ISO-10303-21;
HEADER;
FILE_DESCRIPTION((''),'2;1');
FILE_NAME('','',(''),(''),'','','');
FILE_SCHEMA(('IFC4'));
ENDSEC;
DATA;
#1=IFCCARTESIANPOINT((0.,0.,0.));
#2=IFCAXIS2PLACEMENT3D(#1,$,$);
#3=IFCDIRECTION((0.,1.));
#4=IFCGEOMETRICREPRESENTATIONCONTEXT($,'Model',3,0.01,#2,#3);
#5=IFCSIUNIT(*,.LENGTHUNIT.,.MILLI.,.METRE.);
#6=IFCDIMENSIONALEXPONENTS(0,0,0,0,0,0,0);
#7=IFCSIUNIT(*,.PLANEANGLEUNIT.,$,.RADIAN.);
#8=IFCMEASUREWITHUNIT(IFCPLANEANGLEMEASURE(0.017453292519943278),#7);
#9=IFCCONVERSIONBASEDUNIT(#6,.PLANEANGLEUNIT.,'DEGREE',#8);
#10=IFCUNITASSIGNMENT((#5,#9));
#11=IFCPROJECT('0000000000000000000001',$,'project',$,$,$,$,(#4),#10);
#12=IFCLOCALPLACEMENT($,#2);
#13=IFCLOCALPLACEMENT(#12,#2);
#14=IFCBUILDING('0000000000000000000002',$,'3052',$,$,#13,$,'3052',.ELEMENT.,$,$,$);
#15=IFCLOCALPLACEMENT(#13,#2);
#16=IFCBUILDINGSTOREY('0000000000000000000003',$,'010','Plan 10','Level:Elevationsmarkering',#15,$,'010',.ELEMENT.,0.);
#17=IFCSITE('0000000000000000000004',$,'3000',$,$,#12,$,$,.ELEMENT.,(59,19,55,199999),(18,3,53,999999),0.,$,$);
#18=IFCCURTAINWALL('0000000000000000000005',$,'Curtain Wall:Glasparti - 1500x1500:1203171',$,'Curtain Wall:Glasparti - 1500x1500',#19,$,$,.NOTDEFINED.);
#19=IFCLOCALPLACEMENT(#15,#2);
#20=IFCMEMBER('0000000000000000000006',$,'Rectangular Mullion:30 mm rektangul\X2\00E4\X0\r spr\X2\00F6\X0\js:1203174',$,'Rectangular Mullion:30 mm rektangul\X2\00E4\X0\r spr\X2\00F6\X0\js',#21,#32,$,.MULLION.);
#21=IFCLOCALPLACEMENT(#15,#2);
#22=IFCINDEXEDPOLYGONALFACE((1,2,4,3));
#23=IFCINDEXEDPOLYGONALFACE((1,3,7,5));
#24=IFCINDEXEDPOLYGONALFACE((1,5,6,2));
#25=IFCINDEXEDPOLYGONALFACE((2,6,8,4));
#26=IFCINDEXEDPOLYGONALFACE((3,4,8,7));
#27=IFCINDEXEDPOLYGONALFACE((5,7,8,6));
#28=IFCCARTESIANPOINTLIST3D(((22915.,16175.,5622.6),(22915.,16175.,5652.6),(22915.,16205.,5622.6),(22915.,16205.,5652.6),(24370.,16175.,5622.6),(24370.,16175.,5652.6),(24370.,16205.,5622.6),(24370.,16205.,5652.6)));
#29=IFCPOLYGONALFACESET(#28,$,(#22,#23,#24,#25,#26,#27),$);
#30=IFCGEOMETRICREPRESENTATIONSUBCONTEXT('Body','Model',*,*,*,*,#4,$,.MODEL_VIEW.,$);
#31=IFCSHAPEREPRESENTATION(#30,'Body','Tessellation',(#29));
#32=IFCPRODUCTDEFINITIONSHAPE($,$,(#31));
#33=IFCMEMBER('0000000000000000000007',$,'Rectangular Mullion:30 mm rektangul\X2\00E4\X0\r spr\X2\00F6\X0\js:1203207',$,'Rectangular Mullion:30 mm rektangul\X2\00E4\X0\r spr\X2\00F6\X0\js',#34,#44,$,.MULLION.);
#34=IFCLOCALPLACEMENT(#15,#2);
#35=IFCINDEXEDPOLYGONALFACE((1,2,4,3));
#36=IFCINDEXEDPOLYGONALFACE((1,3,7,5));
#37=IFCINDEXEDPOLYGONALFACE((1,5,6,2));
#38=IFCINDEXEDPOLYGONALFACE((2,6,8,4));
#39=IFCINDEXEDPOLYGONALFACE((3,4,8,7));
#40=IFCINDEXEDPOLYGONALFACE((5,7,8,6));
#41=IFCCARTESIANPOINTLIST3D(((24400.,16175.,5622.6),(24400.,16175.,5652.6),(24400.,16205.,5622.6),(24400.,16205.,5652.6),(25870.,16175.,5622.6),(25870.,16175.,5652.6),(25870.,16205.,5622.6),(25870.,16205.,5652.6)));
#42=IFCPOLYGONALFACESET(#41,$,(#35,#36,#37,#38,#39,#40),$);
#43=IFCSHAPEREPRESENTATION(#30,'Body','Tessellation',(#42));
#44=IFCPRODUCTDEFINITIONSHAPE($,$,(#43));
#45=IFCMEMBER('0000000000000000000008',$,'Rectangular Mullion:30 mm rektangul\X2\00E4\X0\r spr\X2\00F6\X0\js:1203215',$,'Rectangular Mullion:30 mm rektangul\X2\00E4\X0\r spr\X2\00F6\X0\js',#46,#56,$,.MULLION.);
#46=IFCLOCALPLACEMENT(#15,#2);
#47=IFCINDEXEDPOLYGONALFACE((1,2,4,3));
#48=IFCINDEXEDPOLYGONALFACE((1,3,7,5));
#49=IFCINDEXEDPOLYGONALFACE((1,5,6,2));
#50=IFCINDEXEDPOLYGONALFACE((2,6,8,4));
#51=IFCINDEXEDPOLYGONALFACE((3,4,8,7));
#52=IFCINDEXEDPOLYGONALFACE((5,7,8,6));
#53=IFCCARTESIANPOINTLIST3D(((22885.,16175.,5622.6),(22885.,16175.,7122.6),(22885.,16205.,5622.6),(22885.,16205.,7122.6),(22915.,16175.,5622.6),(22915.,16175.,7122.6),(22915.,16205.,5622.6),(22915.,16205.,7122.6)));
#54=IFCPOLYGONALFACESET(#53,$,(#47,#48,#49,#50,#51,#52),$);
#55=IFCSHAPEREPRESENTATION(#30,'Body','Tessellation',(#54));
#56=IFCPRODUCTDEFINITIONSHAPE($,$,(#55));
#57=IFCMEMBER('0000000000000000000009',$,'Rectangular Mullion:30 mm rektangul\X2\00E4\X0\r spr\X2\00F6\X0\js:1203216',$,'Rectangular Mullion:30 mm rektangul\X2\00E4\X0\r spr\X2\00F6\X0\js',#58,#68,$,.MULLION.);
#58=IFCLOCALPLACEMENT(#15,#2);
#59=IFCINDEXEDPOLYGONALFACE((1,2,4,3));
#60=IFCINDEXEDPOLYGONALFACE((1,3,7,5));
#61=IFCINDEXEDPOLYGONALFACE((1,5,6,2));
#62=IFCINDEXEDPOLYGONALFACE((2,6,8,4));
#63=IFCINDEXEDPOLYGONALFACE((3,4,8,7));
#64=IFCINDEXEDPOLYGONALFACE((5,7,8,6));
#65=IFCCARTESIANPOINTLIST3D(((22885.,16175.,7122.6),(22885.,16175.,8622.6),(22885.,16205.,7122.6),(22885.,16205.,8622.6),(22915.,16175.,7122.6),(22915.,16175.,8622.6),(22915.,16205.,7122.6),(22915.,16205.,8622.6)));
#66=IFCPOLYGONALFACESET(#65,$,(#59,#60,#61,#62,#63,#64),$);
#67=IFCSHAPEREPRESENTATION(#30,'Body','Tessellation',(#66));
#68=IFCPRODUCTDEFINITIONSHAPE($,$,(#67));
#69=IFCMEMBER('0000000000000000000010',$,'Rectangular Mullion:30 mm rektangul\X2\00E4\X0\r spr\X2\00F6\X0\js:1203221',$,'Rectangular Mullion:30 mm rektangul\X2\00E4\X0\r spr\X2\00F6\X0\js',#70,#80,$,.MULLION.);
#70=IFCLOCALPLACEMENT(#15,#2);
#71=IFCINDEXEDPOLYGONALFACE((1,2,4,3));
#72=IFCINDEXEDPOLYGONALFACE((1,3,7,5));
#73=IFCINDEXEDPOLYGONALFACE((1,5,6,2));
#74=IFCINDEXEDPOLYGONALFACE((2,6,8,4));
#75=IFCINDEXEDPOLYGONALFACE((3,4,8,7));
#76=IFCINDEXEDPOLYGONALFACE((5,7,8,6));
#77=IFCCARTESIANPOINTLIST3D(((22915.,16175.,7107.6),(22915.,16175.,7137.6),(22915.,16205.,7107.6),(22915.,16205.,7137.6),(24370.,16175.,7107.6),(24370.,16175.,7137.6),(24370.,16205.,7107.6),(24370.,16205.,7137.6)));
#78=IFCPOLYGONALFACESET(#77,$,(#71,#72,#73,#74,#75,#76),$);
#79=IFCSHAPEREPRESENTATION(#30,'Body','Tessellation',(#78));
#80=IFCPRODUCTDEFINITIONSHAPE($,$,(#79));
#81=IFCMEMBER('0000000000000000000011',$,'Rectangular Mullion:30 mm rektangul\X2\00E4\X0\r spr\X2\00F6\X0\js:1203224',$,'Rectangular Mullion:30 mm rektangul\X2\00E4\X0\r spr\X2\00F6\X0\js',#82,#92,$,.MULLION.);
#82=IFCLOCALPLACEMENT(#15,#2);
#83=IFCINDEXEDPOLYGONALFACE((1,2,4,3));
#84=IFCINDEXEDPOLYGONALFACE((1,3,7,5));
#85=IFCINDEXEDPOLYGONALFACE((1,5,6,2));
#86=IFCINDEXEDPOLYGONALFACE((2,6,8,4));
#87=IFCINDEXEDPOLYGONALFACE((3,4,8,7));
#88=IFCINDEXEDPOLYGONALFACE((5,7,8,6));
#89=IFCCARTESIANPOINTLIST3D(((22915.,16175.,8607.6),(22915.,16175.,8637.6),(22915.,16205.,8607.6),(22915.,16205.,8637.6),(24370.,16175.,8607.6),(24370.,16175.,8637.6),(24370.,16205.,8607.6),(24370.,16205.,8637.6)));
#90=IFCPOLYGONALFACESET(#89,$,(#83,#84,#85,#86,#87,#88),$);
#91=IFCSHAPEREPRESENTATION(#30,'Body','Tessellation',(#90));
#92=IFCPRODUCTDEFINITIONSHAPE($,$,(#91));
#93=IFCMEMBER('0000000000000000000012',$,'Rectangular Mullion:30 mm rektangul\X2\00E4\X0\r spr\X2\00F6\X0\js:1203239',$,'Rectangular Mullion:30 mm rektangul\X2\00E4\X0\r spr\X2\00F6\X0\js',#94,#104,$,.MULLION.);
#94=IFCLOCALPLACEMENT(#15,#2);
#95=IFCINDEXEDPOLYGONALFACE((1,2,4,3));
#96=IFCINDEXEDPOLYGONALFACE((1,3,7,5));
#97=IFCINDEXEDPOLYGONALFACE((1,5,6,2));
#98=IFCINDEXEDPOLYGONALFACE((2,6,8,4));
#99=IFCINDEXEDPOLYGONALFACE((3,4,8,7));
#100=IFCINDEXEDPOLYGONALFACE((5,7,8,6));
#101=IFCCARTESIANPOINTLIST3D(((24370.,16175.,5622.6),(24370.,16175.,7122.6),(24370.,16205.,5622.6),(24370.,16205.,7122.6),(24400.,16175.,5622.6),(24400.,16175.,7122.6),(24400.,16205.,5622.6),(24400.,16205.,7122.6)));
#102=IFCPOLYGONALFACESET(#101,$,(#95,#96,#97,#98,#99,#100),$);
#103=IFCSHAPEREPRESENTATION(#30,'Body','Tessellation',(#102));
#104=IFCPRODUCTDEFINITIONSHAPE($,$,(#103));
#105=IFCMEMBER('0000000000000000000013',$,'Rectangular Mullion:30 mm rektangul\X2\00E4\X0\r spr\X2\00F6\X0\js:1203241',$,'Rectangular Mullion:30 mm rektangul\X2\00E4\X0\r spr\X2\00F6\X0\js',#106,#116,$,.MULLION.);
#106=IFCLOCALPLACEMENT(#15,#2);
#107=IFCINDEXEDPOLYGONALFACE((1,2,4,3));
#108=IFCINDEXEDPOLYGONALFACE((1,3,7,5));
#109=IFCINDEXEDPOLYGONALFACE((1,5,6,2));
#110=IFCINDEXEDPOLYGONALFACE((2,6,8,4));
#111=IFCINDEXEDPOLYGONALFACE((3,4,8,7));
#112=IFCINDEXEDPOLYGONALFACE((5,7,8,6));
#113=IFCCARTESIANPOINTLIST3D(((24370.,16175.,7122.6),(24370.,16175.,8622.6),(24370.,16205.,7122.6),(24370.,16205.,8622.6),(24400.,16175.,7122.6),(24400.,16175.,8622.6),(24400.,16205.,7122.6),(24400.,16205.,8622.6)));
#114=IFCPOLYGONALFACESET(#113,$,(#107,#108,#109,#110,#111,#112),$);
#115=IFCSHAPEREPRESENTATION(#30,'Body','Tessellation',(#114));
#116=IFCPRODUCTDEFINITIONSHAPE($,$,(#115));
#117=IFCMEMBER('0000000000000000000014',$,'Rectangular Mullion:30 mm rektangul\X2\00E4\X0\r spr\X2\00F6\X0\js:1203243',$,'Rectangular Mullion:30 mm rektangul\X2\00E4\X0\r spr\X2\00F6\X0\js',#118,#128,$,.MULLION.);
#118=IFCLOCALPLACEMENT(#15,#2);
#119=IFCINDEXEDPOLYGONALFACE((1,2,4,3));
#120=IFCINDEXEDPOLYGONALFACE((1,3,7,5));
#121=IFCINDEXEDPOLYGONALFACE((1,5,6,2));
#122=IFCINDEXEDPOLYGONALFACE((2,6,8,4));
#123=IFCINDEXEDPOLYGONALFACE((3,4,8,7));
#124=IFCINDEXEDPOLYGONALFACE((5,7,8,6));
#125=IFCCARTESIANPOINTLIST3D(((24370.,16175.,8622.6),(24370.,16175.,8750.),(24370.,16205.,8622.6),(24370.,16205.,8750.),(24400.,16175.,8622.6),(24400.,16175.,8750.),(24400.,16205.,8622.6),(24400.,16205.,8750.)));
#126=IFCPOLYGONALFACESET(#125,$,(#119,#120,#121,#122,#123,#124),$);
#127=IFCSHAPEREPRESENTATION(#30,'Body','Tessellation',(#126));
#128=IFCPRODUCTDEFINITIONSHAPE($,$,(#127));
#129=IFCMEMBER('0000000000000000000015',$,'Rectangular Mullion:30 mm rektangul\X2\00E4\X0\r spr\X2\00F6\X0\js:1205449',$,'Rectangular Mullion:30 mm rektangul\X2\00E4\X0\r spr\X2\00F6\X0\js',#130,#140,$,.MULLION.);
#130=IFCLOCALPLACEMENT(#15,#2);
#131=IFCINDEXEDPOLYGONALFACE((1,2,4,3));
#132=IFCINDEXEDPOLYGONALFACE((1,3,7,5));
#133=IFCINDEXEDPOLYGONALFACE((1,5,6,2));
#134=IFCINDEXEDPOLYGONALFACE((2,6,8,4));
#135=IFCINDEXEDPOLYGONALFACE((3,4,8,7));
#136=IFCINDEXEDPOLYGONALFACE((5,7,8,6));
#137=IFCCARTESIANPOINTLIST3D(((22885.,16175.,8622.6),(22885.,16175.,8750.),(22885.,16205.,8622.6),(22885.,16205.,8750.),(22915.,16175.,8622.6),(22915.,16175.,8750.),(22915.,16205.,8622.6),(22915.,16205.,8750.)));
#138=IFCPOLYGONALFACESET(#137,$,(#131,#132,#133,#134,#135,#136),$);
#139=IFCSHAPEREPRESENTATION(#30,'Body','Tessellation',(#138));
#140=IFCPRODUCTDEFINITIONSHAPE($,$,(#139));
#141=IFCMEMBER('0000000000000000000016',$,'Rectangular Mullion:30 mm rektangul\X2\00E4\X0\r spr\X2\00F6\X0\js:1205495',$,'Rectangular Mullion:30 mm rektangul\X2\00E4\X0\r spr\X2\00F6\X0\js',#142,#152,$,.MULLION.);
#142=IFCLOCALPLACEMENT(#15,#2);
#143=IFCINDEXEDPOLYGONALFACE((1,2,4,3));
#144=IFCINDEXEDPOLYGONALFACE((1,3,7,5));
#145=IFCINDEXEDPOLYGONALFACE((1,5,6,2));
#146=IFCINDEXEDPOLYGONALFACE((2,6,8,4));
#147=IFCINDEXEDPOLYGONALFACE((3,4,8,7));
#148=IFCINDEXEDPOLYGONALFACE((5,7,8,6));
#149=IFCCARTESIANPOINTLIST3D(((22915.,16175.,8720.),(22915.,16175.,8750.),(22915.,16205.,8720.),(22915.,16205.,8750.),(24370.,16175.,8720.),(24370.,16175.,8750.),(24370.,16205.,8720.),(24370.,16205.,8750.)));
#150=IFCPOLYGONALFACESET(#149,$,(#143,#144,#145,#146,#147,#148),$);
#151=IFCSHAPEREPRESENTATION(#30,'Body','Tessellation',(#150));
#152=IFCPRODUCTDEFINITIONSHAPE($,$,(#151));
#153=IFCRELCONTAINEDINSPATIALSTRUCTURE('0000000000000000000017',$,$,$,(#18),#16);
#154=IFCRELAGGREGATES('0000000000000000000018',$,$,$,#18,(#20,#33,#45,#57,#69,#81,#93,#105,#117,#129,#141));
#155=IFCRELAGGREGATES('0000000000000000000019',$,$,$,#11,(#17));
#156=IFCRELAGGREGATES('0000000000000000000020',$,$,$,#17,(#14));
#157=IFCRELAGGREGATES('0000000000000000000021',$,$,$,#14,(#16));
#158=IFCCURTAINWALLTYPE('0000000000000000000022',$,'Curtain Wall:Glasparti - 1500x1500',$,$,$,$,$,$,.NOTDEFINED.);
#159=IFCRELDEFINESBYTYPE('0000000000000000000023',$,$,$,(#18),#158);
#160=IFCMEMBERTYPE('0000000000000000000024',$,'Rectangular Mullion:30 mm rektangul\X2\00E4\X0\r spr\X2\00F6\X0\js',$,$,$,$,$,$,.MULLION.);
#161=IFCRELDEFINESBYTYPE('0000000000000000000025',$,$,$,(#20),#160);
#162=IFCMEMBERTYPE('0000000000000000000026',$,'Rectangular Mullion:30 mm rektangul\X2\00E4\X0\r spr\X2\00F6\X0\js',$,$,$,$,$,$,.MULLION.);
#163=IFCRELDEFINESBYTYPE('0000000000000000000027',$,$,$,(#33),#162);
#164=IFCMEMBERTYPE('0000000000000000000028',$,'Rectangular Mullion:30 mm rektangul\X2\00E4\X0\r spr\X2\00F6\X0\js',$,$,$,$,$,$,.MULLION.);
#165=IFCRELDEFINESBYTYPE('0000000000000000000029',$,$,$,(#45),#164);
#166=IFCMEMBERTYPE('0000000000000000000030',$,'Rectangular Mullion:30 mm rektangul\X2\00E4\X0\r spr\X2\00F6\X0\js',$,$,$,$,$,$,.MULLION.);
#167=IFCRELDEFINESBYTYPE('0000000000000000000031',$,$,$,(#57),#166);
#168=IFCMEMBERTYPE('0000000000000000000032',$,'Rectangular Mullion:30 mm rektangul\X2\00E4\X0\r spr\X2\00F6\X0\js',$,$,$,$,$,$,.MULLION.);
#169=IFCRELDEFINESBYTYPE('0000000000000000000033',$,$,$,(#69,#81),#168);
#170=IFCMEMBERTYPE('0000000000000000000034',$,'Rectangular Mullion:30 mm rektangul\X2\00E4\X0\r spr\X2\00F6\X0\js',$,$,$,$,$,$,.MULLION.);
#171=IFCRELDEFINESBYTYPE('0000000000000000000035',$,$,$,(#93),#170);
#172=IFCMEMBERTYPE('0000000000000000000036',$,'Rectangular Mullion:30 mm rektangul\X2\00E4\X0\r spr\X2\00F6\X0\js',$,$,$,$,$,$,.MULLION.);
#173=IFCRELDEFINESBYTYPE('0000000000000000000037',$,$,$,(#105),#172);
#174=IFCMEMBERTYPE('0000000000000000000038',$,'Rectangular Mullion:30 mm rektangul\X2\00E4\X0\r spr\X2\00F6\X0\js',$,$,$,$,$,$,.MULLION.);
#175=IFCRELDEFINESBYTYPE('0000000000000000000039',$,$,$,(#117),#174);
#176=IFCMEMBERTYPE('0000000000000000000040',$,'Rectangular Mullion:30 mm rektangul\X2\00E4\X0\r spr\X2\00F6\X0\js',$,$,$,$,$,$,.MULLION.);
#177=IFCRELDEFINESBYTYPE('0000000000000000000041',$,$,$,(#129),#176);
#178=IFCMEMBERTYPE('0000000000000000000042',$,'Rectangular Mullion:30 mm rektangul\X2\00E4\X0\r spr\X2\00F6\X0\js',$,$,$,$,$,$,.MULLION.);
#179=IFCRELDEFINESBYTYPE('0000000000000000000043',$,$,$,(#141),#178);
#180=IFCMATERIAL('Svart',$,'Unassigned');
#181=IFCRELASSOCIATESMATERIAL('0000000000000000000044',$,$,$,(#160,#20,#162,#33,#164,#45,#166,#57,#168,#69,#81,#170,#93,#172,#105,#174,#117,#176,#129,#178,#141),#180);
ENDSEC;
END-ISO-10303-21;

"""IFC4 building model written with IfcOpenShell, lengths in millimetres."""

from ifc_helpers import new_model, entity, si_unit, converted_unit, direction, frame, origin, place, context, subcontext, project, spatial, indexed_curve, outline, extrude, source, transform, mapped, material, type_object, type_shapes, element, aggregate, save


model = new_model("IFC4")

# Units and contexts
model_context = context("Model", 3, precision=0.01, world=origin(), true_north=direction((0.0, 1.0)))
body_context = subcontext(model_context, "Body", "Model", "MODEL_VIEW")
ifc_project = project(units=[si_unit("LENGTHUNIT", "METRE", prefix="MILLI"), converted_unit("PLANEANGLEUNIT", "DEGREE", entity("IfcPlaneAngleMeasure", 0.017453292519943278), si_unit("PLANEANGLEUNIT", "RADIAN"), dimensions=[0, 0, 0, 0, 0, 0, 0])], contexts=[model_context])

# Site, building, storey
site_placement = place(None, origin())
site = spatial("IfcSite", under=ifc_project, at=site_placement, Name="3000", CompositionType="ELEMENT", RefLatitude=(59, 19, 55, 199999), RefLongitude=(18, 3, 53, 999999), RefElevation=0.0)
building_placement = place(site_placement, origin())
building = spatial("IfcBuilding", under=site, at=building_placement, Name="3052", LongName="3052", CompositionType="ELEMENT")
storey_placement = place(building_placement, origin())
storey = spatial("IfcBuildingStorey", under=building, at=storey_placement, Name="010", Description="Plan 10", ObjectType="Level:Elevationsmarkering", LongName="010", CompositionType="ELEMENT", Elevation=0.0)

# Curtain wall, members
curtain_wall_type = type_object("IfcCurtainWallType", Name="Curtain Wall:Glasparti - 1500x1500", PredefinedType="NOTDEFINED")
curtain_wall_placement = place(storey_placement, origin())
curtain_wall = element("IfcCurtainWall", 1, at=curtain_wall_placement, inside=storey, type_object=curtain_wall_type, Name="Curtain Wall:Glasparti - 1500x1500:1203171", ObjectType="Curtain Wall:Glasparti - 1500x1500", PredefinedType="NOTDEFINED")
ifc_material_1 = material(Name="Svart", Category="Unassigned")
member_type_1 = type_object("IfcMemberType", Name="Rectangular Mullion:30 mm rektangulär spröjs", PredefinedType="MULLION", material=ifc_material_1)
shared_shape_1 = source(origin(), body_context, "Body", "SweptSolid", [
    extrude(outline(indexed_curve([(-15.0, -15.0), (15.0, -15.0), (15.0, 15.0), (-15.0, 15.0), (-15.0, -15.0)], self_intersect=False)), frame((-15.0, 0.0, -1455.0), z_axis=(0.0, 0.0, 1.0), x_axis=(-1.0, 0.0, 0.0)), (0.0, 0.0, 1.0), 1455.0),
])
type_shapes(member_type_1, [shared_shape_1])
member_1_placement = place(curtain_wall_placement, frame((22915.0, 16190.0, 5622.6), z_axis=(-1.0, 0.0, 0.0), x_axis=(0.0, 0.0, -1.0)))
member_1 = element("IfcMember", 2, at=member_1_placement, type_object=member_type_1, material=ifc_material_1, Name="Rectangular Mullion:30 mm rektangulär spröjs:1203174", ObjectType="Rectangular Mullion:30 mm rektangulär spröjs", PredefinedType="MULLION", context=body_context, shape_type="MappedRepresentation", body=[
    mapped(shared_shape_1, transform((0.0, 0.0, 0.0), scale=1.0)),
])
member_type_2 = type_object("IfcMemberType", Name="Rectangular Mullion:30 mm rektangulär spröjs", PredefinedType="MULLION", material=ifc_material_1)
shared_shape_2 = source(origin(), body_context, "Body", "SweptSolid", [
    extrude(outline(indexed_curve([(-15.0, -15.0), (15.0, -15.0), (15.0, 15.0), (-15.0, 15.0), (-15.0, -15.0)], self_intersect=False)), frame((-15.0, 0.0, -1470.0), z_axis=(0.0, 0.0, 1.0), x_axis=(-1.0, 0.0, 0.0)), (0.0, 0.0, 1.0), 1470.0),
])
type_shapes(member_type_2, [shared_shape_2])
member_2_placement = place(curtain_wall_placement, frame((24400.0, 16190.0, 5622.6), z_axis=(-1.0, 0.0, 0.0), x_axis=(0.0, 0.0, -1.0)))
member_2 = element("IfcMember", 3, at=member_2_placement, type_object=member_type_2, material=ifc_material_1, Name="Rectangular Mullion:30 mm rektangulär spröjs:1203207", ObjectType="Rectangular Mullion:30 mm rektangulär spröjs", PredefinedType="MULLION", context=body_context, shape_type="MappedRepresentation", body=[
    mapped(shared_shape_2, transform((0.0, 0.0, 0.0), scale=1.0)),
])
member_type_3 = type_object("IfcMemberType", Name="Rectangular Mullion:30 mm rektangulär spröjs", PredefinedType="MULLION", material=ifc_material_1)
shared_shape_3 = source(origin(), body_context, "Body", "SweptSolid", [
    extrude(outline(indexed_curve([(-15.0, -15.0), (15.0, -15.0), (15.0, 15.0), (-15.0, 15.0), (-15.0, -15.0)], self_intersect=False)), frame((-15.0, 0.0, -1500.0), z_axis=(0.0, 0.0, 1.0), x_axis=(-1.0, 0.0, 0.0)), (0.0, 0.0, 1.0), 1500.0),
])
type_shapes(member_type_3, [shared_shape_3])
member_3_placement = place(curtain_wall_placement, frame((22885.0, 16190.0, 7122.6), z_axis=(0.0, 0.0, 1.0), x_axis=(-1.0, 0.0, 0.0)))
member_3 = element("IfcMember", 4, at=member_3_placement, type_object=member_type_3, material=ifc_material_1, Name="Rectangular Mullion:30 mm rektangulär spröjs:1203215", ObjectType="Rectangular Mullion:30 mm rektangulär spröjs", PredefinedType="MULLION", context=body_context, shape_type="MappedRepresentation", body=[
    mapped(shared_shape_3, transform((0.0, 0.0, 0.0), scale=1.0)),
])
member_type_4 = type_object("IfcMemberType", Name="Rectangular Mullion:30 mm rektangulär spröjs", PredefinedType="MULLION", material=ifc_material_1)
shared_shape_4 = source(origin(), body_context, "Body", "SweptSolid", [
    extrude(outline(indexed_curve([(-15.0, -15.0), (15.0, -15.0), (15.0, 15.0), (-15.0, 15.0), (-15.0, -15.0)], self_intersect=False)), frame((-15.0, 0.0, -1500.0), z_axis=(0.0, 0.0, 1.0), x_axis=(-1.0, 0.0, 0.0)), (0.0, 0.0, 1.0), 1500.0),
])
type_shapes(member_type_4, [shared_shape_4])
member_4_placement = place(curtain_wall_placement, frame((22885.0, 16190.0, 8622.6), z_axis=(0.0, 0.0, 1.0), x_axis=(-1.0, 0.0, 0.0)))
member_4 = element("IfcMember", 5, at=member_4_placement, type_object=member_type_4, material=ifc_material_1, Name="Rectangular Mullion:30 mm rektangulär spröjs:1203216", ObjectType="Rectangular Mullion:30 mm rektangulär spröjs", PredefinedType="MULLION", context=body_context, shape_type="MappedRepresentation", body=[
    mapped(shared_shape_4, transform((0.0, 0.0, 0.0), scale=1.0)),
])
member_type_5 = type_object("IfcMemberType", Name="Rectangular Mullion:30 mm rektangulär spröjs", PredefinedType="MULLION", material=ifc_material_1)
shared_shape_5 = source(origin(), body_context, "Body", "SweptSolid", [
    extrude(outline(indexed_curve([(-15.0, -15.0), (15.0, -15.0), (15.0, 15.0), (-15.0, 15.0), (-15.0, -15.0)], self_intersect=False)), frame((0.0, 0.0, -1455.0), z_axis=(0.0, 0.0, 1.0), x_axis=(-1.0, 0.0, 0.0)), (0.0, 0.0, 1.0), 1455.0),
])
type_shapes(member_type_5, [shared_shape_5])
member_5_placement = place(curtain_wall_placement, frame((24370.0, 16190.0, 7122.6), z_axis=(1.0, 0.0, 0.0), x_axis=(0.0, 0.0, 1.0)))
member_5 = element("IfcMember", 6, at=member_5_placement, type_object=member_type_5, material=ifc_material_1, Name="Rectangular Mullion:30 mm rektangulär spröjs:1203221", ObjectType="Rectangular Mullion:30 mm rektangulär spröjs", PredefinedType="MULLION", context=body_context, shape_type="MappedRepresentation", body=[
    mapped(shared_shape_5, transform((0.0, 0.0, 0.0), scale=1.0)),
])
member_6_placement = place(curtain_wall_placement, frame((24370.0, 16190.0, 8622.6), z_axis=(1.0, 0.0, 0.0), x_axis=(0.0, 0.0, 1.0)))
member_6 = element("IfcMember", 7, at=member_6_placement, type_object=member_type_5, material=ifc_material_1, Name="Rectangular Mullion:30 mm rektangulär spröjs:1203224", ObjectType="Rectangular Mullion:30 mm rektangulär spröjs", PredefinedType="MULLION", context=body_context, shape_type="MappedRepresentation", body=[
    mapped(shared_shape_5, transform((0.0, 0.0, 0.0), scale=1.0)),
])
member_type_6 = type_object("IfcMemberType", Name="Rectangular Mullion:30 mm rektangulär spröjs", PredefinedType="MULLION", material=ifc_material_1)
shared_shape_6 = source(origin(), body_context, "Body", "SweptSolid", [
    extrude(outline(indexed_curve([(-15.0, -15.0), (15.0, -15.0), (15.0, 15.0), (-15.0, 15.0), (-15.0, -15.0)], self_intersect=False)), frame((0.0, 0.0, -1500.0), z_axis=(0.0, 0.0, 1.0), x_axis=(-1.0, 0.0, 0.0)), (0.0, 0.0, 1.0), 1500.0),
])
type_shapes(member_type_6, [shared_shape_6])
member_7_placement = place(curtain_wall_placement, frame((24385.0, 16190.0, 5622.6), z_axis=(0.0, 0.0, -1.0), x_axis=(1.0, 0.0, 0.0)))
member_7 = element("IfcMember", 8, at=member_7_placement, type_object=member_type_6, material=ifc_material_1, Name="Rectangular Mullion:30 mm rektangulär spröjs:1203239", ObjectType="Rectangular Mullion:30 mm rektangulär spröjs", PredefinedType="MULLION", context=body_context, shape_type="MappedRepresentation", body=[
    mapped(shared_shape_6, transform((0.0, 0.0, 0.0), scale=1.0)),
])
member_type_7 = type_object("IfcMemberType", Name="Rectangular Mullion:30 mm rektangulär spröjs", PredefinedType="MULLION", material=ifc_material_1)
shared_shape_7 = source(origin(), body_context, "Body", "SweptSolid", [
    extrude(outline(indexed_curve([(-15.0, -15.0), (15.0, -15.0), (15.0, 15.0), (-15.0, 15.0), (-15.0, -15.0)], self_intersect=False)), frame((0.0, 0.0, -1500.0), z_axis=(0.0, 0.0, 1.0), x_axis=(-1.0, 0.0, 0.0)), (0.0, 0.0, 1.0), 1500.0),
])
type_shapes(member_type_7, [shared_shape_7])
member_8_placement = place(curtain_wall_placement, frame((24385.0, 16190.0, 7122.6), z_axis=(0.0, 0.0, -1.0), x_axis=(1.0, 0.0, 0.0)))
member_8 = element("IfcMember", 9, at=member_8_placement, type_object=member_type_7, material=ifc_material_1, Name="Rectangular Mullion:30 mm rektangulär spröjs:1203241", ObjectType="Rectangular Mullion:30 mm rektangulär spröjs", PredefinedType="MULLION", context=body_context, shape_type="MappedRepresentation", body=[
    mapped(shared_shape_7, transform((0.0, 0.0, 0.0), scale=1.0)),
])
member_type_8 = type_object("IfcMemberType", Name="Rectangular Mullion:30 mm rektangulär spröjs", PredefinedType="MULLION", material=ifc_material_1)
shared_shape_8 = source(origin(), body_context, "Body", "SweptSolid", [
    extrude(outline(indexed_curve([(-15.0, -15.0), (15.0, -15.0), (15.0, 15.0), (-15.0, 15.0), (-15.0, -15.0)], self_intersect=False)), frame((0.0, 0.0, -127.4), z_axis=(0.0, 0.0, 1.0), x_axis=(-1.0, 0.0, 0.0)), (0.0, 0.0, 1.0), 127.4),
])
type_shapes(member_type_8, [shared_shape_8])
member_9_placement = place(curtain_wall_placement, frame((24385.0, 16190.0, 8622.6), z_axis=(0.0, 0.0, -1.0), x_axis=(1.0, 0.0, 0.0)))
member_9 = element("IfcMember", 10, at=member_9_placement, type_object=member_type_8, material=ifc_material_1, Name="Rectangular Mullion:30 mm rektangulär spröjs:1203243", ObjectType="Rectangular Mullion:30 mm rektangulär spröjs", PredefinedType="MULLION", context=body_context, shape_type="MappedRepresentation", body=[
    mapped(shared_shape_8, transform((0.0, 0.0, 0.0), scale=1.0)),
])
member_type_9 = type_object("IfcMemberType", Name="Rectangular Mullion:30 mm rektangulär spröjs", PredefinedType="MULLION", material=ifc_material_1)
shared_shape_9 = source(origin(), body_context, "Body", "SweptSolid", [
    extrude(outline(indexed_curve([(-15.0, -15.0), (15.0, -15.0), (15.0, 15.0), (-15.0, 15.0), (-15.0, -15.0)], self_intersect=False)), frame((-15.0, 0.0, -127.4), z_axis=(0.0, 0.0, 1.0), x_axis=(-1.0, 0.0, 0.0)), (0.0, 0.0, 1.0), 127.4),
])
type_shapes(member_type_9, [shared_shape_9])
member_10_placement = place(curtain_wall_placement, frame((22885.0, 16190.0, 8750.0), z_axis=(0.0, 0.0, 1.0), x_axis=(-1.0, 0.0, 0.0)))
member_10 = element("IfcMember", 11, at=member_10_placement, type_object=member_type_9, material=ifc_material_1, Name="Rectangular Mullion:30 mm rektangulär spröjs:1205449", ObjectType="Rectangular Mullion:30 mm rektangulär spröjs", PredefinedType="MULLION", context=body_context, shape_type="MappedRepresentation", body=[
    mapped(shared_shape_9, transform((0.0, 0.0, 0.0), scale=1.0)),
])
member_type_10 = type_object("IfcMemberType", Name="Rectangular Mullion:30 mm rektangulär spröjs", PredefinedType="MULLION", material=ifc_material_1)
shared_shape_10 = source(origin(), body_context, "Body", "SweptSolid", [
    extrude(outline(indexed_curve([(-15.0, -15.0), (15.0, -15.0), (15.0, 15.0), (-15.0, 15.0), (-15.0, -15.0)], self_intersect=False)), frame((-15.0, 0.0, -1455.0), z_axis=(0.0, 0.0, 1.0), x_axis=(-1.0, 0.0, 0.0)), (0.0, 0.0, 1.0), 1455.0),
])
type_shapes(member_type_10, [shared_shape_10])
member_11_placement = place(curtain_wall_placement, frame((24370.0, 16190.0, 8750.0), z_axis=(1.0, 0.0, 0.0), x_axis=(0.0, 0.0, 1.0)))
member_11 = element("IfcMember", 12, at=member_11_placement, type_object=member_type_10, material=ifc_material_1, Name="Rectangular Mullion:30 mm rektangulär spröjs:1205495", ObjectType="Rectangular Mullion:30 mm rektangulär spröjs", PredefinedType="MULLION", context=body_context, shape_type="MappedRepresentation", body=[
    mapped(shared_shape_10, transform((0.0, 0.0, 0.0), scale=1.0)),
])
aggregate(curtain_wall, [member_1, member_2, member_3, member_4, member_5, member_6, member_7, member_8, member_9, member_10, member_11])

save(model, "model.ifc")
